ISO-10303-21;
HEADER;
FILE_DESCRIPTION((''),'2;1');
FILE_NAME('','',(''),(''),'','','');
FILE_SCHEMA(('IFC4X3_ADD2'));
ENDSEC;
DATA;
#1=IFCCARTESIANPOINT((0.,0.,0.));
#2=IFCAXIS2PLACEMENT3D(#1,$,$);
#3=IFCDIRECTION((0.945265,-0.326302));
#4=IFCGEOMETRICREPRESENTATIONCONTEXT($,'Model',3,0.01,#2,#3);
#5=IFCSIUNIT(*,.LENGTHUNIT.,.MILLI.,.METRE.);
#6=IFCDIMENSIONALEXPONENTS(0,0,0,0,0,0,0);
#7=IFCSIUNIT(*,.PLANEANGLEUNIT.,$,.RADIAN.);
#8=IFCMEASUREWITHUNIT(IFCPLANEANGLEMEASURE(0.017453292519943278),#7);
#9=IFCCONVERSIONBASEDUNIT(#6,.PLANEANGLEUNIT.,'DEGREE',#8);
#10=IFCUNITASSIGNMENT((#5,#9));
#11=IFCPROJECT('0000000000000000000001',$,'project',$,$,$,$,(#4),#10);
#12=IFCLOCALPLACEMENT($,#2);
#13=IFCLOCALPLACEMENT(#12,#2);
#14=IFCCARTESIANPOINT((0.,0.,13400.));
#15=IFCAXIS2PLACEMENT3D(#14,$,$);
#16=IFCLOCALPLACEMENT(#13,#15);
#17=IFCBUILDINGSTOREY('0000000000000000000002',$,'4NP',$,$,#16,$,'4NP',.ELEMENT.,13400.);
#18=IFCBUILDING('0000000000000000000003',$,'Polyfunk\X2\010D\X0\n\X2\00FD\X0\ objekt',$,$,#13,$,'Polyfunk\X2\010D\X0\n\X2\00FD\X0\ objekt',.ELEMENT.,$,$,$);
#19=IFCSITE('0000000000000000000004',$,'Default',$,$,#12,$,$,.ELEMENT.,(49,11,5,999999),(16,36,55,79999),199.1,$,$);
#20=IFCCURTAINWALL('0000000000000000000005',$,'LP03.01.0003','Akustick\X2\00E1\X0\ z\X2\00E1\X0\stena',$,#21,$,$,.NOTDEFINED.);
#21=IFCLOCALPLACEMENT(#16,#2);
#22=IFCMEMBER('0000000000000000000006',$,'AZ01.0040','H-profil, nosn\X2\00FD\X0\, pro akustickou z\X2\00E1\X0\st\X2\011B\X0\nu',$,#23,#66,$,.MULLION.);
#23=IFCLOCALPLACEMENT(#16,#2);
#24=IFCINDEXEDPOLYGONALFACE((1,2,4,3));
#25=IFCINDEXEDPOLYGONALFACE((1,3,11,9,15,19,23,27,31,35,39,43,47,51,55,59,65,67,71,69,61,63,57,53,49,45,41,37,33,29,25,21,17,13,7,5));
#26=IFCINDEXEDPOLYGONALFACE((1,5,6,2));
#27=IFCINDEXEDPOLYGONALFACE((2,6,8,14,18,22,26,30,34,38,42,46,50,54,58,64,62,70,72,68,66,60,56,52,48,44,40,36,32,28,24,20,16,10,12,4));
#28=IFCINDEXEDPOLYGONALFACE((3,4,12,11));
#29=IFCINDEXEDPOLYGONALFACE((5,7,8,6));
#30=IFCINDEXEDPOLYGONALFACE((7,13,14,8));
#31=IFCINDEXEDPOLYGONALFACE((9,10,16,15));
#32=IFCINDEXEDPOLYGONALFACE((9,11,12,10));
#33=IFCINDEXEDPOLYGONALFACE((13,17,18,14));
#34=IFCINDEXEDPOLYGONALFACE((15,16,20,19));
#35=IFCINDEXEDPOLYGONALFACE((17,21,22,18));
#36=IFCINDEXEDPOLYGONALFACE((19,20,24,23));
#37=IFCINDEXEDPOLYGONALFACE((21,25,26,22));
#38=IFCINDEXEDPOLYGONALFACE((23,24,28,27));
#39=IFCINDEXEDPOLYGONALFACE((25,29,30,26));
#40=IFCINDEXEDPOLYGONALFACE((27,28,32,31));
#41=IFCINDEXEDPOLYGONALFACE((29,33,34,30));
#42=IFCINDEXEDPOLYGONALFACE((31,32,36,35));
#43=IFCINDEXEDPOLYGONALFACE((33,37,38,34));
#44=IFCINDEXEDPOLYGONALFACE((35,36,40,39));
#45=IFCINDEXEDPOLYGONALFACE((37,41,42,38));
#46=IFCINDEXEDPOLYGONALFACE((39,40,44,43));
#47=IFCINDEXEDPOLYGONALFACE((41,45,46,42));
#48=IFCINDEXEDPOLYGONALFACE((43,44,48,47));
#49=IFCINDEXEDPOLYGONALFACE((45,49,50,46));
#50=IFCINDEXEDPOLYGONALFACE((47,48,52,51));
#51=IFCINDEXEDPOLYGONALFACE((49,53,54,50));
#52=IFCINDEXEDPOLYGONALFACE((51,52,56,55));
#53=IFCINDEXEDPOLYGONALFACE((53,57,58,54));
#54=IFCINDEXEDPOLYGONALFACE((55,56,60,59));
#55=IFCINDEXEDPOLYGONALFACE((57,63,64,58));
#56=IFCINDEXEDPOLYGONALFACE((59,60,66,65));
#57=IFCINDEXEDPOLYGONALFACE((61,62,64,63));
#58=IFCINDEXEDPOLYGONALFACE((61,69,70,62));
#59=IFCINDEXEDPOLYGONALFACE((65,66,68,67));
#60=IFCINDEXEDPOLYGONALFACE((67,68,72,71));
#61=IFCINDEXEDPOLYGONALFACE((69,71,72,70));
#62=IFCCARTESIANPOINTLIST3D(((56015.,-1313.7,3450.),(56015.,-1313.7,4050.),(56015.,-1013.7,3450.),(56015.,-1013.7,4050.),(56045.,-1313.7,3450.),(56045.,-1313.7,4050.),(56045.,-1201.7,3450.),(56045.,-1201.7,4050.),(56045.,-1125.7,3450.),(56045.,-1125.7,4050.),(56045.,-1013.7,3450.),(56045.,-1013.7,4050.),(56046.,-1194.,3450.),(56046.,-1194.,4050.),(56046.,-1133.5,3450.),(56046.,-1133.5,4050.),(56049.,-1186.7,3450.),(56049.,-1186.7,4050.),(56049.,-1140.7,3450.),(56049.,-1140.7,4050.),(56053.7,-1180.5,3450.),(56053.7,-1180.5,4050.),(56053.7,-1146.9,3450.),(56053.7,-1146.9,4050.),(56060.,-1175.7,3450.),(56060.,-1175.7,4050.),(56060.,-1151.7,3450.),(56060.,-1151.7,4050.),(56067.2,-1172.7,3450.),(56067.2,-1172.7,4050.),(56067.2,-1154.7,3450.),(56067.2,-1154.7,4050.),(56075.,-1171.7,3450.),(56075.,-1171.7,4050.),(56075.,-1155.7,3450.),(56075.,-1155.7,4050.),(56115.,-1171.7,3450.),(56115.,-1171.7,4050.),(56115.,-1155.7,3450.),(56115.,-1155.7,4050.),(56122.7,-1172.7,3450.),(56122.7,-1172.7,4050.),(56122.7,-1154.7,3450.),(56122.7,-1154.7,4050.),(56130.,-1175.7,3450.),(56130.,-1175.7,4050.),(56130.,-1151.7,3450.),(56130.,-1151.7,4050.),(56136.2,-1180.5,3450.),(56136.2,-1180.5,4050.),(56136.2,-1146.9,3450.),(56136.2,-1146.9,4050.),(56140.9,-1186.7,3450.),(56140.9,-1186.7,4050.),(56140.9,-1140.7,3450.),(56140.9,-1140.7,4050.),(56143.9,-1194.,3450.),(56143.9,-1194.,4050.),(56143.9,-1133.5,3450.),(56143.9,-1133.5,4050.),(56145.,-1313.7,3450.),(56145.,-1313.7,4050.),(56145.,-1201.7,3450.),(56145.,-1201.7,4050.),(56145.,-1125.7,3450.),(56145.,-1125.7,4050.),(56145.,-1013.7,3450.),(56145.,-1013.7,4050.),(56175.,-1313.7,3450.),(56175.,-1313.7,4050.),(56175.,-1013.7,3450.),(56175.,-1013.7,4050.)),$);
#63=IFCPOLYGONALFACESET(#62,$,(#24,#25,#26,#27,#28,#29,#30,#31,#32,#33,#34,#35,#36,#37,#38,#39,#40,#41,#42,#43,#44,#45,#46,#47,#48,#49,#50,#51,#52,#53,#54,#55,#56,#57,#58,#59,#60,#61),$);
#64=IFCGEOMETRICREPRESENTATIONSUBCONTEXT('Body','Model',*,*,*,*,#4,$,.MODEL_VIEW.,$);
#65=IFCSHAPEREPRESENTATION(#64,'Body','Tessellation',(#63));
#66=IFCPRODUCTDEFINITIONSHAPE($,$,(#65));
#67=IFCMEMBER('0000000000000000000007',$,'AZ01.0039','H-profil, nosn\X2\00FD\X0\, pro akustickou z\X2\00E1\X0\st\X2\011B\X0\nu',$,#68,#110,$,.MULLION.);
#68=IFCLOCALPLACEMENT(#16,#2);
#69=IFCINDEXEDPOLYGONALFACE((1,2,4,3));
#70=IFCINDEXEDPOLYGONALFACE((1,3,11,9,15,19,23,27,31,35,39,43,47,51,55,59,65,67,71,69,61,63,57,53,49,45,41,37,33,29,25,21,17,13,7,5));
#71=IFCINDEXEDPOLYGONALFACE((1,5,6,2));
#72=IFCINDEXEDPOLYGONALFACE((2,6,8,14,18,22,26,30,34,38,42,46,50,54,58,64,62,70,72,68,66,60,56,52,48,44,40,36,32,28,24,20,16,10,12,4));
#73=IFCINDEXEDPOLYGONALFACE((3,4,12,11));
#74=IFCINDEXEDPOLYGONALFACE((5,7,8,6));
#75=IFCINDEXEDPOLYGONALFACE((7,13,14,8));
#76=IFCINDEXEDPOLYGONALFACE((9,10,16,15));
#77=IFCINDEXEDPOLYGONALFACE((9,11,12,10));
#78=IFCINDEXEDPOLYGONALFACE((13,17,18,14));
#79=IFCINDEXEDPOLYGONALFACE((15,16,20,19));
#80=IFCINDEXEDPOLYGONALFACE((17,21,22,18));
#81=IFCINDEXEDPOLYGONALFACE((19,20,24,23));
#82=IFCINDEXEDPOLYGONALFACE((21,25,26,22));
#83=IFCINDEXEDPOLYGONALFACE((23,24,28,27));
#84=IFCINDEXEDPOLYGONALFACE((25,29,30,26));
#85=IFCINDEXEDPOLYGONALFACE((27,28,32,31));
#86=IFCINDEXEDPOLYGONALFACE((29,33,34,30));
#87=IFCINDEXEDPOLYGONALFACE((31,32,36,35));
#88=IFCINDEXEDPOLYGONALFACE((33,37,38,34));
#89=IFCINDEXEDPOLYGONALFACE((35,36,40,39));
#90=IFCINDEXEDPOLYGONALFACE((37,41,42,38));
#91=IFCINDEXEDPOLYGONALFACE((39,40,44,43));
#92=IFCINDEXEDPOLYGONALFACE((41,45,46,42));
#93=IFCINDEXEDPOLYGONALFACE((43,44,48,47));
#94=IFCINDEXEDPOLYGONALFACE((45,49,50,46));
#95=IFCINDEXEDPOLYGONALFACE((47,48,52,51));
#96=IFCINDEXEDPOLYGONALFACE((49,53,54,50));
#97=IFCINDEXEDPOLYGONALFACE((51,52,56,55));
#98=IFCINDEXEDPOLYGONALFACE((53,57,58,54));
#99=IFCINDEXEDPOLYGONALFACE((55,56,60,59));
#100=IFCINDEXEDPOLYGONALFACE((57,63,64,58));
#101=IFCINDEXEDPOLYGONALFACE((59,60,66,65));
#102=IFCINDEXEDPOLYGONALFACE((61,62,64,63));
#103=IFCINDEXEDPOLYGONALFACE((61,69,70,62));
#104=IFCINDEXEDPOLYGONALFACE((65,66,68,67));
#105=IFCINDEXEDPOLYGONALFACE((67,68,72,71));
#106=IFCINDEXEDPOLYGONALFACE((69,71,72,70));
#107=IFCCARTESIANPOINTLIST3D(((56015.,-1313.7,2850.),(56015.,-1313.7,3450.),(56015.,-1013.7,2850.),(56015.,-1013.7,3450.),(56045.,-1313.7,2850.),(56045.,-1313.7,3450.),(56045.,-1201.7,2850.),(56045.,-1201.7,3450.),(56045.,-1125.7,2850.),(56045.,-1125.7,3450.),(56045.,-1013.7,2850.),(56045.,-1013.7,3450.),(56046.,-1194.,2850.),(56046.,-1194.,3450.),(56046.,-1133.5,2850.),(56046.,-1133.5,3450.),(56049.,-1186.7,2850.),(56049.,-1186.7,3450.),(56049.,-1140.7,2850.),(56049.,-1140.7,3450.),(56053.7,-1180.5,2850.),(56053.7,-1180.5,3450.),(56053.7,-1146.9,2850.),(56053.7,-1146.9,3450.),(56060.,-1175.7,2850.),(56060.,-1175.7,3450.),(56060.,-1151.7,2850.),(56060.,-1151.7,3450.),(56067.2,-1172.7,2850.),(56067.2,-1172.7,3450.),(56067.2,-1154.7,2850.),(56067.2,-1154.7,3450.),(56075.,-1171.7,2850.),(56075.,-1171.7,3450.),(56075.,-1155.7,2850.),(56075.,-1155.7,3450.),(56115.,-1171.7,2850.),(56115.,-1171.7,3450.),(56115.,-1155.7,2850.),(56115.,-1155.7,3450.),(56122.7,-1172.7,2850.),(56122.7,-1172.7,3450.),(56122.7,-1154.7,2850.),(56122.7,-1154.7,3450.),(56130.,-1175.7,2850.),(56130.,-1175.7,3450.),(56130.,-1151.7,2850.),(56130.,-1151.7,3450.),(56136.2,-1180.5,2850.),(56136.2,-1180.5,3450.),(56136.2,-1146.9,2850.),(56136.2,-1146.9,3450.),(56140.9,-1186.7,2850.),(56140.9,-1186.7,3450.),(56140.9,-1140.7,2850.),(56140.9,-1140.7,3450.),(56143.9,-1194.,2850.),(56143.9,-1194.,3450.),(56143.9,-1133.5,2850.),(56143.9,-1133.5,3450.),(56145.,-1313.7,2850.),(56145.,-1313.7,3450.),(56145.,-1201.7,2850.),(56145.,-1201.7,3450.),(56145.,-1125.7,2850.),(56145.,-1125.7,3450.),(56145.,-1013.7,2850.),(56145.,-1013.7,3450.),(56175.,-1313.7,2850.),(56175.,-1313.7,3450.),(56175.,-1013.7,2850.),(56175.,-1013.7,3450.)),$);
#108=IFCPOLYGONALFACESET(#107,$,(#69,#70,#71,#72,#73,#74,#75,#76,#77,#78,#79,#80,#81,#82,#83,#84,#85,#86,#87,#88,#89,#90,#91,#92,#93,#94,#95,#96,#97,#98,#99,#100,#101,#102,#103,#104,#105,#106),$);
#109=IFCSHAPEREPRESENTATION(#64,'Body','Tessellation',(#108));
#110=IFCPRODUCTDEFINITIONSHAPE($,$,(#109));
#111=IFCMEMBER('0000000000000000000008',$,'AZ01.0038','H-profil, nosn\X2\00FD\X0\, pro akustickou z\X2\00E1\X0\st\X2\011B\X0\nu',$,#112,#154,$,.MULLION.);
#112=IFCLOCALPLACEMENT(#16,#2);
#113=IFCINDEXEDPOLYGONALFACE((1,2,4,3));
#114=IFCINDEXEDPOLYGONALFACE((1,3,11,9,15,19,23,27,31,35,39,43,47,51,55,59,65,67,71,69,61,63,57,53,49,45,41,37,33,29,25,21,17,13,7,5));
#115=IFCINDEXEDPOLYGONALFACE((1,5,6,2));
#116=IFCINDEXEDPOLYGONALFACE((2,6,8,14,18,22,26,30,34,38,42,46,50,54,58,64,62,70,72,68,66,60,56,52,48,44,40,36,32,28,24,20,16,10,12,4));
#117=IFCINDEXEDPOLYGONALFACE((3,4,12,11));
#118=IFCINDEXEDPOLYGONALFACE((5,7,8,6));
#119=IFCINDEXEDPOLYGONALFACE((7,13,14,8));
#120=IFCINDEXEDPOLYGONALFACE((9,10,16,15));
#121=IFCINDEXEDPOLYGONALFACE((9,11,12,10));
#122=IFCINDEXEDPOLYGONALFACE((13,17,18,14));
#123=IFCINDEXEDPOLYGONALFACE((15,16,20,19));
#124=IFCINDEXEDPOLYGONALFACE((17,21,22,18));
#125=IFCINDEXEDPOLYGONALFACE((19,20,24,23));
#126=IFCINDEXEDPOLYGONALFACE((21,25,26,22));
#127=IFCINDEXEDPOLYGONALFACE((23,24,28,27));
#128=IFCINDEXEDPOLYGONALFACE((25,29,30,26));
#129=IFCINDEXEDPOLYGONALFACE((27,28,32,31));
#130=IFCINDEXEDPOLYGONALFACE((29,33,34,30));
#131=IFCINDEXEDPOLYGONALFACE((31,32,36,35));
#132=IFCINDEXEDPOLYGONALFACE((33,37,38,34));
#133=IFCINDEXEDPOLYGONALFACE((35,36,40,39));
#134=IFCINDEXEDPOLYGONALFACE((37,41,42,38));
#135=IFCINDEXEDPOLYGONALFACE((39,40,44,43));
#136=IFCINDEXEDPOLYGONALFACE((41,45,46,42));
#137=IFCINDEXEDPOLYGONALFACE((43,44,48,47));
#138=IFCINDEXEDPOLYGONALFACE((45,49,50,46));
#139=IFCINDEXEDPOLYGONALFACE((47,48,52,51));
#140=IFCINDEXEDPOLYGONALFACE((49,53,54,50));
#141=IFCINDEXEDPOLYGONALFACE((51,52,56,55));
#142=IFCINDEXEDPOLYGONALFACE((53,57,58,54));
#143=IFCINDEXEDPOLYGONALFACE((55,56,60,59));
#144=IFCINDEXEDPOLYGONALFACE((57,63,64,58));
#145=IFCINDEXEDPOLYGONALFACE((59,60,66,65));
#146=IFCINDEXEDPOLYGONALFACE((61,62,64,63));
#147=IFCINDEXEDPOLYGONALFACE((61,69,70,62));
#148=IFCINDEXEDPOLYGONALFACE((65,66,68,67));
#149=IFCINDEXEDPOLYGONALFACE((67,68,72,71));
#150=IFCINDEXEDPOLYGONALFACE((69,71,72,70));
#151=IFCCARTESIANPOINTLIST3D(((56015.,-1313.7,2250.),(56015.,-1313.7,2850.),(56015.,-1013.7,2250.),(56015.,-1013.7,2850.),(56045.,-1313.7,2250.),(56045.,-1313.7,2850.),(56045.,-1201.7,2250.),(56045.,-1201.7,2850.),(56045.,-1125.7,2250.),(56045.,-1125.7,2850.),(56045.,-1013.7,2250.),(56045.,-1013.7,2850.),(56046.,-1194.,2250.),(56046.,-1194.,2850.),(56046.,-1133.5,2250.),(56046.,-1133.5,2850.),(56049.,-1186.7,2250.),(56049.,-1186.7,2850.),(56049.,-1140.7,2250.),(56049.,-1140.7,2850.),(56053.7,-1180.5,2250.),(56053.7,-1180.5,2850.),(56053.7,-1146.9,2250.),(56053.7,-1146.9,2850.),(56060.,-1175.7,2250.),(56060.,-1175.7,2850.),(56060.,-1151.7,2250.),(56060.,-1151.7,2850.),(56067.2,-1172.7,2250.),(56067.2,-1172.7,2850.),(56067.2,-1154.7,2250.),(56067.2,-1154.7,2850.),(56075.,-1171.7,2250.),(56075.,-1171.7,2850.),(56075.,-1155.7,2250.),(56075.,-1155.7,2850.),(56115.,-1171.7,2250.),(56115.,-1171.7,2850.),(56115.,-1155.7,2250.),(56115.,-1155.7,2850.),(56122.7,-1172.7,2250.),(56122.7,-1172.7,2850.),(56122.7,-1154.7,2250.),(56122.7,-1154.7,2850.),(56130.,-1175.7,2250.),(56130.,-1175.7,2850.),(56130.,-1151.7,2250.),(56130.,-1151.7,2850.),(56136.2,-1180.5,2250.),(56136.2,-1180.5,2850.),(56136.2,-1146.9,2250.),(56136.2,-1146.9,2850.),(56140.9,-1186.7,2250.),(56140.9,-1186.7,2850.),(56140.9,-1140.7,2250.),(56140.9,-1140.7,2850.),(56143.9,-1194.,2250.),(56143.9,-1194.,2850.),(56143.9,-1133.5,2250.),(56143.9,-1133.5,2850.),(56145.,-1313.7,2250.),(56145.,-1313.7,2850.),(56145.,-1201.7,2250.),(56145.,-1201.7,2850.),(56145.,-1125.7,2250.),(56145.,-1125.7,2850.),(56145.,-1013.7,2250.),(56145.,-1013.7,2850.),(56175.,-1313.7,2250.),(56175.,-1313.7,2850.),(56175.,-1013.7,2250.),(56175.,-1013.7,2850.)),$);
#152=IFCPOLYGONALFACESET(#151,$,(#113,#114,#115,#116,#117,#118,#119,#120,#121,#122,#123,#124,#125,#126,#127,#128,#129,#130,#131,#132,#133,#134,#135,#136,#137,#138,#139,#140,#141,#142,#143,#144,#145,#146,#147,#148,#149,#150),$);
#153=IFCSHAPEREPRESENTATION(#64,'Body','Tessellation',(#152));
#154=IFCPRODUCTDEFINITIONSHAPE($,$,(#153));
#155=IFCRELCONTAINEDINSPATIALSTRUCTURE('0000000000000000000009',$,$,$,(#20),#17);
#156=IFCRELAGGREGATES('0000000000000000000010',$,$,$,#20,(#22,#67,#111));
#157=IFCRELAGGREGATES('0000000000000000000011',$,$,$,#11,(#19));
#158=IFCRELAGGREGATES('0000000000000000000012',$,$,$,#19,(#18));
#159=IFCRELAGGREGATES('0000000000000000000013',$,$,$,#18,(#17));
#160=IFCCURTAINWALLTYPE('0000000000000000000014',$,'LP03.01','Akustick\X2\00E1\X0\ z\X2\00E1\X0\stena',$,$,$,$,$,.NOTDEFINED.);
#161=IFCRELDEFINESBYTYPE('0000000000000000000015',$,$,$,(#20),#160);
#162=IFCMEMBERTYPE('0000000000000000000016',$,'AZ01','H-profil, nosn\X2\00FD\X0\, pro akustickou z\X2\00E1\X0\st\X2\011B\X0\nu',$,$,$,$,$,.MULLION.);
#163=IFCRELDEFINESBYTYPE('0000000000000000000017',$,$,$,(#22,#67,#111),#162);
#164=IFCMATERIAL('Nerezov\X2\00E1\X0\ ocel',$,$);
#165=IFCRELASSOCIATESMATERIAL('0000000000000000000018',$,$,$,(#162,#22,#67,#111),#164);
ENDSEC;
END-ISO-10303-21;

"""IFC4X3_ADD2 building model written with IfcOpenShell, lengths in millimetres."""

from ifc_helpers import new_model, entity, si_unit, converted_unit, direction, frame, frame_2d, origin, place, context, subcontext, project, spatial, polyline, circle_curve, parameter, trimmed, segment, composite_curve, outline, extrude, source, transform, mapped, material, material_profile, profile_set, profile_usage, type_object, element, aggregate, save


model = new_model("IFC4X3_ADD2")

# Units and contexts
model_context = context("Model", 3, precision=0.01, world=origin(), true_north=direction((0.945265, -0.326302)))
body_context = subcontext(model_context, "Body", "Model", "MODEL_VIEW")
ifc_project = project(units=[si_unit("LENGTHUNIT", "METRE", prefix="MILLI"), converted_unit("PLANEANGLEUNIT", "DEGREE", entity("IfcPlaneAngleMeasure", 0.017453292519943278), si_unit("PLANEANGLEUNIT", "RADIAN"), dimensions=[0, 0, 0, 0, 0, 0, 0])], contexts=[model_context])

# Site, building, storey
site_placement = place(None, origin())
site = spatial("IfcSite", under=ifc_project, at=site_placement, Name="Default", CompositionType="ELEMENT", RefLatitude=(49, 11, 5, 999999), RefLongitude=(16, 36, 55, 79999), RefElevation=199.1)
building_placement = place(site_placement, origin())
building = spatial("IfcBuilding", under=site, at=building_placement, Name="Polyfunkčný objekt", LongName="Polyfunkčný objekt", CompositionType="ELEMENT")
storey_placement = place(building_placement, frame((0.0, 0.0, 13400.0)))
storey = spatial("IfcBuildingStorey", under=building, at=storey_placement, Name="4NP", LongName="4NP", CompositionType="ELEMENT", Elevation=13400.0)

# Curtain wall, members
curtain_wall_type = type_object("IfcCurtainWallType", Name="LP03.01", Description="Akustická zástena", PredefinedType="NOTDEFINED")
curtain_wall_1_placement = place(storey_placement, frame((0.0, 0.0, -13400.0)))
curtain_wall_1 = element("IfcCurtainWall", 1, at=curtain_wall_1_placement, inside=storey, type_object=curtain_wall_type, Name="LP03.01.0003", Description="Akustická zástena", PredefinedType="NOTDEFINED")
ifc_material_1 = material(Name="Nerezová ocel")
ifc_material_profile = material_profile(ifc_material_1, outline(composite_curve([segment(polyline([(50.0, -150.0), (80.0, -150.0)]), True, "CONTINUOUS"), segment(polyline([(80.0, -150.0), (80.0, 150.0)]), True, "CONTINUOUS"), segment(polyline([(80.0, 150.0), (50.0, 150.0)]), True, "CONTINUOUS"), segment(polyline([(50.0, 150.0), (50.0, 38.0)]), True, "CONTINUOUS"), segment(trimmed(circle_curve(frame_2d((20.0, 38.0), x_axis=(0.0, 1.0)), 30.0), [parameter(180.0)], [parameter(270.0)], True, "PARAMETER"), False, "CONTINUOUS"), segment(polyline([(20.0, 8.0), (-20.0, 8.0)]), True, "CONTINUOUS"), segment(trimmed(circle_curve(frame_2d((-20.0, 38.0), x_axis=(0.0, 1.0)), 30.0), [parameter(90.0)], [parameter(180.0)], True, "PARAMETER"), False, "CONTINUOUS"), segment(polyline([(-50.0, 38.0), (-50.0, 150.0)]), True, "CONTINUOUS"), segment(polyline([(-50.0, 150.0), (-80.0, 150.0)]), True, "CONTINUOUS"), segment(polyline([(-80.0, 150.0), (-80.0, -150.0)]), True, "CONTINUOUS"), segment(polyline([(-80.0, -150.0), (-50.0, -150.0)]), True, "CONTINUOUS"), segment(polyline([(-50.0, -150.0), (-50.0, -38.0)]), True, "CONTINUOUS"), segment(trimmed(circle_curve(frame_2d((-20.0, -38.0), x_axis=(0.0, 1.0)), 30.0), [parameter(0.0)], [parameter(90.0)], True, "PARAMETER"), False, "CONTINUOUS"), segment(polyline([(-20.0, -8.0), (20.0, -8.0)]), True, "CONTINUOUS"), segment(trimmed(circle_curve(frame_2d((20.0, -38.0), x_axis=(0.0, 1.0)), 30.0), [parameter(270.0)], [parameter(0.0)], True, "PARAMETER"), False, "CONTINUOUS"), segment(polyline([(50.0, -38.0), (50.0, -150.0)]), True, "CONTINUOUS")], self_intersect=False)), Name="Profil zástena")
ifc_profile_set = profile_set([ifc_material_profile], Name="Profil zástena")
ifc_profile_usage = profile_usage(ifc_profile_set)
member_type = type_object("IfcMemberType", Name="AZ01", Description="H-profil, nosný, pro akustickou zástěnu", PredefinedType="MULLION", material=ifc_profile_set)
shared_shape_1 = source(origin(), body_context, "Body", "SweptSolid", [
    extrude(outline(composite_curve([segment(polyline([(50.0, -150.0), (80.0, -150.0)]), True, "CONTINUOUS"), segment(polyline([(80.0, -150.0), (80.0, 150.0)]), True, "CONTINUOUS"), segment(polyline([(80.0, 150.0), (50.0, 150.0)]), True, "CONTINUOUS"), segment(polyline([(50.0, 150.0), (50.0, 38.0)]), True, "CONTINUOUS"), segment(trimmed(circle_curve(frame_2d((20.0, 38.0), x_axis=(0.0, 1.0)), 30.0), [parameter(180.0)], [parameter(270.0)], True, "PARAMETER"), False, "CONTINUOUS"), segment(polyline([(20.0, 8.0), (-20.0, 8.0)]), True, "CONTINUOUS"), segment(trimmed(circle_curve(frame_2d((-20.0, 38.0), x_axis=(0.0, 1.0)), 30.0), [parameter(90.0)], [parameter(180.0)], True, "PARAMETER"), False, "CONTINUOUS"), segment(polyline([(-50.0, 38.0), (-50.0, 150.0)]), True, "CONTINUOUS"), segment(polyline([(-50.0, 150.0), (-80.0, 150.0)]), True, "CONTINUOUS"), segment(polyline([(-80.0, 150.0), (-80.0, -150.0)]), True, "CONTINUOUS"), segment(polyline([(-80.0, -150.0), (-50.0, -150.0)]), True, "CONTINUOUS"), segment(polyline([(-50.0, -150.0), (-50.0, -38.0)]), True, "CONTINUOUS"), segment(trimmed(circle_curve(frame_2d((-20.0, -38.0), x_axis=(0.0, 1.0)), 30.0), [parameter(0.0)], [parameter(90.0)], True, "PARAMETER"), False, "CONTINUOUS"), segment(polyline([(-20.0, -8.0), (20.0, -8.0)]), True, "CONTINUOUS"), segment(trimmed(circle_curve(frame_2d((20.0, -38.0), x_axis=(0.0, 1.0)), 30.0), [parameter(270.0)], [parameter(0.0)], True, "PARAMETER"), False, "CONTINUOUS"), segment(polyline([(50.0, -38.0), (50.0, -150.0)]), True, "CONTINUOUS")], self_intersect=False)), frame((-150.0, 0.0, -600.0), z_axis=(0.0, 0.0, 1.0), x_axis=(0.0, 1.0, 0.0)), (0.0, 0.0, 1.0), 600.0),
])
member_1_placement = place(curtain_wall_1_placement, frame((56095.0, -1313.7, 17450.0), z_axis=(0.0, 0.0, 1.0), x_axis=(0.0, -1.0, 0.0)))
member_1 = element("IfcMember", 2, at=member_1_placement, type_object=member_type, material=ifc_profile_usage, Name="AZ01.0040", Description="H-profil, nosný, pro akustickou zástěnu", PredefinedType="MULLION", context=body_context, shape_type="MappedRepresentation", body=[
    mapped(shared_shape_1, transform((0.0, 0.0, 0.0), scale=1.0)),
])
member_2_placement = place(curtain_wall_1_placement, frame((56095.0, -1313.7, 16850.0), z_axis=(0.0, 0.0, 1.0), x_axis=(0.0, -1.0, 0.0)))
member_2 = element("IfcMember", 3, at=member_2_placement, type_object=member_type, material=ifc_profile_usage, Name="AZ01.0039", Description="H-profil, nosný, pro akustickou zástěnu", PredefinedType="MULLION", context=body_context, shape_type="MappedRepresentation", body=[
    mapped(shared_shape_1, transform((0.0, 0.0, 0.0), scale=1.0)),
])
member_3_placement = place(curtain_wall_1_placement, frame((56095.0, -1313.7, 16250.0), z_axis=(0.0, 0.0, 1.0), x_axis=(0.0, -1.0, 0.0)))
member_3 = element("IfcMember", 4, at=member_3_placement, type_object=member_type, material=ifc_profile_usage, Name="AZ01.0038", Description="H-profil, nosný, pro akustickou zástěnu", PredefinedType="MULLION", context=body_context, shape_type="MappedRepresentation", body=[
    mapped(shared_shape_1, transform((0.0, 0.0, 0.0), scale=1.0)),
])

aggregate(curtain_wall_1, [member_1, member_2, member_3])

save(model, "model.ifc")
